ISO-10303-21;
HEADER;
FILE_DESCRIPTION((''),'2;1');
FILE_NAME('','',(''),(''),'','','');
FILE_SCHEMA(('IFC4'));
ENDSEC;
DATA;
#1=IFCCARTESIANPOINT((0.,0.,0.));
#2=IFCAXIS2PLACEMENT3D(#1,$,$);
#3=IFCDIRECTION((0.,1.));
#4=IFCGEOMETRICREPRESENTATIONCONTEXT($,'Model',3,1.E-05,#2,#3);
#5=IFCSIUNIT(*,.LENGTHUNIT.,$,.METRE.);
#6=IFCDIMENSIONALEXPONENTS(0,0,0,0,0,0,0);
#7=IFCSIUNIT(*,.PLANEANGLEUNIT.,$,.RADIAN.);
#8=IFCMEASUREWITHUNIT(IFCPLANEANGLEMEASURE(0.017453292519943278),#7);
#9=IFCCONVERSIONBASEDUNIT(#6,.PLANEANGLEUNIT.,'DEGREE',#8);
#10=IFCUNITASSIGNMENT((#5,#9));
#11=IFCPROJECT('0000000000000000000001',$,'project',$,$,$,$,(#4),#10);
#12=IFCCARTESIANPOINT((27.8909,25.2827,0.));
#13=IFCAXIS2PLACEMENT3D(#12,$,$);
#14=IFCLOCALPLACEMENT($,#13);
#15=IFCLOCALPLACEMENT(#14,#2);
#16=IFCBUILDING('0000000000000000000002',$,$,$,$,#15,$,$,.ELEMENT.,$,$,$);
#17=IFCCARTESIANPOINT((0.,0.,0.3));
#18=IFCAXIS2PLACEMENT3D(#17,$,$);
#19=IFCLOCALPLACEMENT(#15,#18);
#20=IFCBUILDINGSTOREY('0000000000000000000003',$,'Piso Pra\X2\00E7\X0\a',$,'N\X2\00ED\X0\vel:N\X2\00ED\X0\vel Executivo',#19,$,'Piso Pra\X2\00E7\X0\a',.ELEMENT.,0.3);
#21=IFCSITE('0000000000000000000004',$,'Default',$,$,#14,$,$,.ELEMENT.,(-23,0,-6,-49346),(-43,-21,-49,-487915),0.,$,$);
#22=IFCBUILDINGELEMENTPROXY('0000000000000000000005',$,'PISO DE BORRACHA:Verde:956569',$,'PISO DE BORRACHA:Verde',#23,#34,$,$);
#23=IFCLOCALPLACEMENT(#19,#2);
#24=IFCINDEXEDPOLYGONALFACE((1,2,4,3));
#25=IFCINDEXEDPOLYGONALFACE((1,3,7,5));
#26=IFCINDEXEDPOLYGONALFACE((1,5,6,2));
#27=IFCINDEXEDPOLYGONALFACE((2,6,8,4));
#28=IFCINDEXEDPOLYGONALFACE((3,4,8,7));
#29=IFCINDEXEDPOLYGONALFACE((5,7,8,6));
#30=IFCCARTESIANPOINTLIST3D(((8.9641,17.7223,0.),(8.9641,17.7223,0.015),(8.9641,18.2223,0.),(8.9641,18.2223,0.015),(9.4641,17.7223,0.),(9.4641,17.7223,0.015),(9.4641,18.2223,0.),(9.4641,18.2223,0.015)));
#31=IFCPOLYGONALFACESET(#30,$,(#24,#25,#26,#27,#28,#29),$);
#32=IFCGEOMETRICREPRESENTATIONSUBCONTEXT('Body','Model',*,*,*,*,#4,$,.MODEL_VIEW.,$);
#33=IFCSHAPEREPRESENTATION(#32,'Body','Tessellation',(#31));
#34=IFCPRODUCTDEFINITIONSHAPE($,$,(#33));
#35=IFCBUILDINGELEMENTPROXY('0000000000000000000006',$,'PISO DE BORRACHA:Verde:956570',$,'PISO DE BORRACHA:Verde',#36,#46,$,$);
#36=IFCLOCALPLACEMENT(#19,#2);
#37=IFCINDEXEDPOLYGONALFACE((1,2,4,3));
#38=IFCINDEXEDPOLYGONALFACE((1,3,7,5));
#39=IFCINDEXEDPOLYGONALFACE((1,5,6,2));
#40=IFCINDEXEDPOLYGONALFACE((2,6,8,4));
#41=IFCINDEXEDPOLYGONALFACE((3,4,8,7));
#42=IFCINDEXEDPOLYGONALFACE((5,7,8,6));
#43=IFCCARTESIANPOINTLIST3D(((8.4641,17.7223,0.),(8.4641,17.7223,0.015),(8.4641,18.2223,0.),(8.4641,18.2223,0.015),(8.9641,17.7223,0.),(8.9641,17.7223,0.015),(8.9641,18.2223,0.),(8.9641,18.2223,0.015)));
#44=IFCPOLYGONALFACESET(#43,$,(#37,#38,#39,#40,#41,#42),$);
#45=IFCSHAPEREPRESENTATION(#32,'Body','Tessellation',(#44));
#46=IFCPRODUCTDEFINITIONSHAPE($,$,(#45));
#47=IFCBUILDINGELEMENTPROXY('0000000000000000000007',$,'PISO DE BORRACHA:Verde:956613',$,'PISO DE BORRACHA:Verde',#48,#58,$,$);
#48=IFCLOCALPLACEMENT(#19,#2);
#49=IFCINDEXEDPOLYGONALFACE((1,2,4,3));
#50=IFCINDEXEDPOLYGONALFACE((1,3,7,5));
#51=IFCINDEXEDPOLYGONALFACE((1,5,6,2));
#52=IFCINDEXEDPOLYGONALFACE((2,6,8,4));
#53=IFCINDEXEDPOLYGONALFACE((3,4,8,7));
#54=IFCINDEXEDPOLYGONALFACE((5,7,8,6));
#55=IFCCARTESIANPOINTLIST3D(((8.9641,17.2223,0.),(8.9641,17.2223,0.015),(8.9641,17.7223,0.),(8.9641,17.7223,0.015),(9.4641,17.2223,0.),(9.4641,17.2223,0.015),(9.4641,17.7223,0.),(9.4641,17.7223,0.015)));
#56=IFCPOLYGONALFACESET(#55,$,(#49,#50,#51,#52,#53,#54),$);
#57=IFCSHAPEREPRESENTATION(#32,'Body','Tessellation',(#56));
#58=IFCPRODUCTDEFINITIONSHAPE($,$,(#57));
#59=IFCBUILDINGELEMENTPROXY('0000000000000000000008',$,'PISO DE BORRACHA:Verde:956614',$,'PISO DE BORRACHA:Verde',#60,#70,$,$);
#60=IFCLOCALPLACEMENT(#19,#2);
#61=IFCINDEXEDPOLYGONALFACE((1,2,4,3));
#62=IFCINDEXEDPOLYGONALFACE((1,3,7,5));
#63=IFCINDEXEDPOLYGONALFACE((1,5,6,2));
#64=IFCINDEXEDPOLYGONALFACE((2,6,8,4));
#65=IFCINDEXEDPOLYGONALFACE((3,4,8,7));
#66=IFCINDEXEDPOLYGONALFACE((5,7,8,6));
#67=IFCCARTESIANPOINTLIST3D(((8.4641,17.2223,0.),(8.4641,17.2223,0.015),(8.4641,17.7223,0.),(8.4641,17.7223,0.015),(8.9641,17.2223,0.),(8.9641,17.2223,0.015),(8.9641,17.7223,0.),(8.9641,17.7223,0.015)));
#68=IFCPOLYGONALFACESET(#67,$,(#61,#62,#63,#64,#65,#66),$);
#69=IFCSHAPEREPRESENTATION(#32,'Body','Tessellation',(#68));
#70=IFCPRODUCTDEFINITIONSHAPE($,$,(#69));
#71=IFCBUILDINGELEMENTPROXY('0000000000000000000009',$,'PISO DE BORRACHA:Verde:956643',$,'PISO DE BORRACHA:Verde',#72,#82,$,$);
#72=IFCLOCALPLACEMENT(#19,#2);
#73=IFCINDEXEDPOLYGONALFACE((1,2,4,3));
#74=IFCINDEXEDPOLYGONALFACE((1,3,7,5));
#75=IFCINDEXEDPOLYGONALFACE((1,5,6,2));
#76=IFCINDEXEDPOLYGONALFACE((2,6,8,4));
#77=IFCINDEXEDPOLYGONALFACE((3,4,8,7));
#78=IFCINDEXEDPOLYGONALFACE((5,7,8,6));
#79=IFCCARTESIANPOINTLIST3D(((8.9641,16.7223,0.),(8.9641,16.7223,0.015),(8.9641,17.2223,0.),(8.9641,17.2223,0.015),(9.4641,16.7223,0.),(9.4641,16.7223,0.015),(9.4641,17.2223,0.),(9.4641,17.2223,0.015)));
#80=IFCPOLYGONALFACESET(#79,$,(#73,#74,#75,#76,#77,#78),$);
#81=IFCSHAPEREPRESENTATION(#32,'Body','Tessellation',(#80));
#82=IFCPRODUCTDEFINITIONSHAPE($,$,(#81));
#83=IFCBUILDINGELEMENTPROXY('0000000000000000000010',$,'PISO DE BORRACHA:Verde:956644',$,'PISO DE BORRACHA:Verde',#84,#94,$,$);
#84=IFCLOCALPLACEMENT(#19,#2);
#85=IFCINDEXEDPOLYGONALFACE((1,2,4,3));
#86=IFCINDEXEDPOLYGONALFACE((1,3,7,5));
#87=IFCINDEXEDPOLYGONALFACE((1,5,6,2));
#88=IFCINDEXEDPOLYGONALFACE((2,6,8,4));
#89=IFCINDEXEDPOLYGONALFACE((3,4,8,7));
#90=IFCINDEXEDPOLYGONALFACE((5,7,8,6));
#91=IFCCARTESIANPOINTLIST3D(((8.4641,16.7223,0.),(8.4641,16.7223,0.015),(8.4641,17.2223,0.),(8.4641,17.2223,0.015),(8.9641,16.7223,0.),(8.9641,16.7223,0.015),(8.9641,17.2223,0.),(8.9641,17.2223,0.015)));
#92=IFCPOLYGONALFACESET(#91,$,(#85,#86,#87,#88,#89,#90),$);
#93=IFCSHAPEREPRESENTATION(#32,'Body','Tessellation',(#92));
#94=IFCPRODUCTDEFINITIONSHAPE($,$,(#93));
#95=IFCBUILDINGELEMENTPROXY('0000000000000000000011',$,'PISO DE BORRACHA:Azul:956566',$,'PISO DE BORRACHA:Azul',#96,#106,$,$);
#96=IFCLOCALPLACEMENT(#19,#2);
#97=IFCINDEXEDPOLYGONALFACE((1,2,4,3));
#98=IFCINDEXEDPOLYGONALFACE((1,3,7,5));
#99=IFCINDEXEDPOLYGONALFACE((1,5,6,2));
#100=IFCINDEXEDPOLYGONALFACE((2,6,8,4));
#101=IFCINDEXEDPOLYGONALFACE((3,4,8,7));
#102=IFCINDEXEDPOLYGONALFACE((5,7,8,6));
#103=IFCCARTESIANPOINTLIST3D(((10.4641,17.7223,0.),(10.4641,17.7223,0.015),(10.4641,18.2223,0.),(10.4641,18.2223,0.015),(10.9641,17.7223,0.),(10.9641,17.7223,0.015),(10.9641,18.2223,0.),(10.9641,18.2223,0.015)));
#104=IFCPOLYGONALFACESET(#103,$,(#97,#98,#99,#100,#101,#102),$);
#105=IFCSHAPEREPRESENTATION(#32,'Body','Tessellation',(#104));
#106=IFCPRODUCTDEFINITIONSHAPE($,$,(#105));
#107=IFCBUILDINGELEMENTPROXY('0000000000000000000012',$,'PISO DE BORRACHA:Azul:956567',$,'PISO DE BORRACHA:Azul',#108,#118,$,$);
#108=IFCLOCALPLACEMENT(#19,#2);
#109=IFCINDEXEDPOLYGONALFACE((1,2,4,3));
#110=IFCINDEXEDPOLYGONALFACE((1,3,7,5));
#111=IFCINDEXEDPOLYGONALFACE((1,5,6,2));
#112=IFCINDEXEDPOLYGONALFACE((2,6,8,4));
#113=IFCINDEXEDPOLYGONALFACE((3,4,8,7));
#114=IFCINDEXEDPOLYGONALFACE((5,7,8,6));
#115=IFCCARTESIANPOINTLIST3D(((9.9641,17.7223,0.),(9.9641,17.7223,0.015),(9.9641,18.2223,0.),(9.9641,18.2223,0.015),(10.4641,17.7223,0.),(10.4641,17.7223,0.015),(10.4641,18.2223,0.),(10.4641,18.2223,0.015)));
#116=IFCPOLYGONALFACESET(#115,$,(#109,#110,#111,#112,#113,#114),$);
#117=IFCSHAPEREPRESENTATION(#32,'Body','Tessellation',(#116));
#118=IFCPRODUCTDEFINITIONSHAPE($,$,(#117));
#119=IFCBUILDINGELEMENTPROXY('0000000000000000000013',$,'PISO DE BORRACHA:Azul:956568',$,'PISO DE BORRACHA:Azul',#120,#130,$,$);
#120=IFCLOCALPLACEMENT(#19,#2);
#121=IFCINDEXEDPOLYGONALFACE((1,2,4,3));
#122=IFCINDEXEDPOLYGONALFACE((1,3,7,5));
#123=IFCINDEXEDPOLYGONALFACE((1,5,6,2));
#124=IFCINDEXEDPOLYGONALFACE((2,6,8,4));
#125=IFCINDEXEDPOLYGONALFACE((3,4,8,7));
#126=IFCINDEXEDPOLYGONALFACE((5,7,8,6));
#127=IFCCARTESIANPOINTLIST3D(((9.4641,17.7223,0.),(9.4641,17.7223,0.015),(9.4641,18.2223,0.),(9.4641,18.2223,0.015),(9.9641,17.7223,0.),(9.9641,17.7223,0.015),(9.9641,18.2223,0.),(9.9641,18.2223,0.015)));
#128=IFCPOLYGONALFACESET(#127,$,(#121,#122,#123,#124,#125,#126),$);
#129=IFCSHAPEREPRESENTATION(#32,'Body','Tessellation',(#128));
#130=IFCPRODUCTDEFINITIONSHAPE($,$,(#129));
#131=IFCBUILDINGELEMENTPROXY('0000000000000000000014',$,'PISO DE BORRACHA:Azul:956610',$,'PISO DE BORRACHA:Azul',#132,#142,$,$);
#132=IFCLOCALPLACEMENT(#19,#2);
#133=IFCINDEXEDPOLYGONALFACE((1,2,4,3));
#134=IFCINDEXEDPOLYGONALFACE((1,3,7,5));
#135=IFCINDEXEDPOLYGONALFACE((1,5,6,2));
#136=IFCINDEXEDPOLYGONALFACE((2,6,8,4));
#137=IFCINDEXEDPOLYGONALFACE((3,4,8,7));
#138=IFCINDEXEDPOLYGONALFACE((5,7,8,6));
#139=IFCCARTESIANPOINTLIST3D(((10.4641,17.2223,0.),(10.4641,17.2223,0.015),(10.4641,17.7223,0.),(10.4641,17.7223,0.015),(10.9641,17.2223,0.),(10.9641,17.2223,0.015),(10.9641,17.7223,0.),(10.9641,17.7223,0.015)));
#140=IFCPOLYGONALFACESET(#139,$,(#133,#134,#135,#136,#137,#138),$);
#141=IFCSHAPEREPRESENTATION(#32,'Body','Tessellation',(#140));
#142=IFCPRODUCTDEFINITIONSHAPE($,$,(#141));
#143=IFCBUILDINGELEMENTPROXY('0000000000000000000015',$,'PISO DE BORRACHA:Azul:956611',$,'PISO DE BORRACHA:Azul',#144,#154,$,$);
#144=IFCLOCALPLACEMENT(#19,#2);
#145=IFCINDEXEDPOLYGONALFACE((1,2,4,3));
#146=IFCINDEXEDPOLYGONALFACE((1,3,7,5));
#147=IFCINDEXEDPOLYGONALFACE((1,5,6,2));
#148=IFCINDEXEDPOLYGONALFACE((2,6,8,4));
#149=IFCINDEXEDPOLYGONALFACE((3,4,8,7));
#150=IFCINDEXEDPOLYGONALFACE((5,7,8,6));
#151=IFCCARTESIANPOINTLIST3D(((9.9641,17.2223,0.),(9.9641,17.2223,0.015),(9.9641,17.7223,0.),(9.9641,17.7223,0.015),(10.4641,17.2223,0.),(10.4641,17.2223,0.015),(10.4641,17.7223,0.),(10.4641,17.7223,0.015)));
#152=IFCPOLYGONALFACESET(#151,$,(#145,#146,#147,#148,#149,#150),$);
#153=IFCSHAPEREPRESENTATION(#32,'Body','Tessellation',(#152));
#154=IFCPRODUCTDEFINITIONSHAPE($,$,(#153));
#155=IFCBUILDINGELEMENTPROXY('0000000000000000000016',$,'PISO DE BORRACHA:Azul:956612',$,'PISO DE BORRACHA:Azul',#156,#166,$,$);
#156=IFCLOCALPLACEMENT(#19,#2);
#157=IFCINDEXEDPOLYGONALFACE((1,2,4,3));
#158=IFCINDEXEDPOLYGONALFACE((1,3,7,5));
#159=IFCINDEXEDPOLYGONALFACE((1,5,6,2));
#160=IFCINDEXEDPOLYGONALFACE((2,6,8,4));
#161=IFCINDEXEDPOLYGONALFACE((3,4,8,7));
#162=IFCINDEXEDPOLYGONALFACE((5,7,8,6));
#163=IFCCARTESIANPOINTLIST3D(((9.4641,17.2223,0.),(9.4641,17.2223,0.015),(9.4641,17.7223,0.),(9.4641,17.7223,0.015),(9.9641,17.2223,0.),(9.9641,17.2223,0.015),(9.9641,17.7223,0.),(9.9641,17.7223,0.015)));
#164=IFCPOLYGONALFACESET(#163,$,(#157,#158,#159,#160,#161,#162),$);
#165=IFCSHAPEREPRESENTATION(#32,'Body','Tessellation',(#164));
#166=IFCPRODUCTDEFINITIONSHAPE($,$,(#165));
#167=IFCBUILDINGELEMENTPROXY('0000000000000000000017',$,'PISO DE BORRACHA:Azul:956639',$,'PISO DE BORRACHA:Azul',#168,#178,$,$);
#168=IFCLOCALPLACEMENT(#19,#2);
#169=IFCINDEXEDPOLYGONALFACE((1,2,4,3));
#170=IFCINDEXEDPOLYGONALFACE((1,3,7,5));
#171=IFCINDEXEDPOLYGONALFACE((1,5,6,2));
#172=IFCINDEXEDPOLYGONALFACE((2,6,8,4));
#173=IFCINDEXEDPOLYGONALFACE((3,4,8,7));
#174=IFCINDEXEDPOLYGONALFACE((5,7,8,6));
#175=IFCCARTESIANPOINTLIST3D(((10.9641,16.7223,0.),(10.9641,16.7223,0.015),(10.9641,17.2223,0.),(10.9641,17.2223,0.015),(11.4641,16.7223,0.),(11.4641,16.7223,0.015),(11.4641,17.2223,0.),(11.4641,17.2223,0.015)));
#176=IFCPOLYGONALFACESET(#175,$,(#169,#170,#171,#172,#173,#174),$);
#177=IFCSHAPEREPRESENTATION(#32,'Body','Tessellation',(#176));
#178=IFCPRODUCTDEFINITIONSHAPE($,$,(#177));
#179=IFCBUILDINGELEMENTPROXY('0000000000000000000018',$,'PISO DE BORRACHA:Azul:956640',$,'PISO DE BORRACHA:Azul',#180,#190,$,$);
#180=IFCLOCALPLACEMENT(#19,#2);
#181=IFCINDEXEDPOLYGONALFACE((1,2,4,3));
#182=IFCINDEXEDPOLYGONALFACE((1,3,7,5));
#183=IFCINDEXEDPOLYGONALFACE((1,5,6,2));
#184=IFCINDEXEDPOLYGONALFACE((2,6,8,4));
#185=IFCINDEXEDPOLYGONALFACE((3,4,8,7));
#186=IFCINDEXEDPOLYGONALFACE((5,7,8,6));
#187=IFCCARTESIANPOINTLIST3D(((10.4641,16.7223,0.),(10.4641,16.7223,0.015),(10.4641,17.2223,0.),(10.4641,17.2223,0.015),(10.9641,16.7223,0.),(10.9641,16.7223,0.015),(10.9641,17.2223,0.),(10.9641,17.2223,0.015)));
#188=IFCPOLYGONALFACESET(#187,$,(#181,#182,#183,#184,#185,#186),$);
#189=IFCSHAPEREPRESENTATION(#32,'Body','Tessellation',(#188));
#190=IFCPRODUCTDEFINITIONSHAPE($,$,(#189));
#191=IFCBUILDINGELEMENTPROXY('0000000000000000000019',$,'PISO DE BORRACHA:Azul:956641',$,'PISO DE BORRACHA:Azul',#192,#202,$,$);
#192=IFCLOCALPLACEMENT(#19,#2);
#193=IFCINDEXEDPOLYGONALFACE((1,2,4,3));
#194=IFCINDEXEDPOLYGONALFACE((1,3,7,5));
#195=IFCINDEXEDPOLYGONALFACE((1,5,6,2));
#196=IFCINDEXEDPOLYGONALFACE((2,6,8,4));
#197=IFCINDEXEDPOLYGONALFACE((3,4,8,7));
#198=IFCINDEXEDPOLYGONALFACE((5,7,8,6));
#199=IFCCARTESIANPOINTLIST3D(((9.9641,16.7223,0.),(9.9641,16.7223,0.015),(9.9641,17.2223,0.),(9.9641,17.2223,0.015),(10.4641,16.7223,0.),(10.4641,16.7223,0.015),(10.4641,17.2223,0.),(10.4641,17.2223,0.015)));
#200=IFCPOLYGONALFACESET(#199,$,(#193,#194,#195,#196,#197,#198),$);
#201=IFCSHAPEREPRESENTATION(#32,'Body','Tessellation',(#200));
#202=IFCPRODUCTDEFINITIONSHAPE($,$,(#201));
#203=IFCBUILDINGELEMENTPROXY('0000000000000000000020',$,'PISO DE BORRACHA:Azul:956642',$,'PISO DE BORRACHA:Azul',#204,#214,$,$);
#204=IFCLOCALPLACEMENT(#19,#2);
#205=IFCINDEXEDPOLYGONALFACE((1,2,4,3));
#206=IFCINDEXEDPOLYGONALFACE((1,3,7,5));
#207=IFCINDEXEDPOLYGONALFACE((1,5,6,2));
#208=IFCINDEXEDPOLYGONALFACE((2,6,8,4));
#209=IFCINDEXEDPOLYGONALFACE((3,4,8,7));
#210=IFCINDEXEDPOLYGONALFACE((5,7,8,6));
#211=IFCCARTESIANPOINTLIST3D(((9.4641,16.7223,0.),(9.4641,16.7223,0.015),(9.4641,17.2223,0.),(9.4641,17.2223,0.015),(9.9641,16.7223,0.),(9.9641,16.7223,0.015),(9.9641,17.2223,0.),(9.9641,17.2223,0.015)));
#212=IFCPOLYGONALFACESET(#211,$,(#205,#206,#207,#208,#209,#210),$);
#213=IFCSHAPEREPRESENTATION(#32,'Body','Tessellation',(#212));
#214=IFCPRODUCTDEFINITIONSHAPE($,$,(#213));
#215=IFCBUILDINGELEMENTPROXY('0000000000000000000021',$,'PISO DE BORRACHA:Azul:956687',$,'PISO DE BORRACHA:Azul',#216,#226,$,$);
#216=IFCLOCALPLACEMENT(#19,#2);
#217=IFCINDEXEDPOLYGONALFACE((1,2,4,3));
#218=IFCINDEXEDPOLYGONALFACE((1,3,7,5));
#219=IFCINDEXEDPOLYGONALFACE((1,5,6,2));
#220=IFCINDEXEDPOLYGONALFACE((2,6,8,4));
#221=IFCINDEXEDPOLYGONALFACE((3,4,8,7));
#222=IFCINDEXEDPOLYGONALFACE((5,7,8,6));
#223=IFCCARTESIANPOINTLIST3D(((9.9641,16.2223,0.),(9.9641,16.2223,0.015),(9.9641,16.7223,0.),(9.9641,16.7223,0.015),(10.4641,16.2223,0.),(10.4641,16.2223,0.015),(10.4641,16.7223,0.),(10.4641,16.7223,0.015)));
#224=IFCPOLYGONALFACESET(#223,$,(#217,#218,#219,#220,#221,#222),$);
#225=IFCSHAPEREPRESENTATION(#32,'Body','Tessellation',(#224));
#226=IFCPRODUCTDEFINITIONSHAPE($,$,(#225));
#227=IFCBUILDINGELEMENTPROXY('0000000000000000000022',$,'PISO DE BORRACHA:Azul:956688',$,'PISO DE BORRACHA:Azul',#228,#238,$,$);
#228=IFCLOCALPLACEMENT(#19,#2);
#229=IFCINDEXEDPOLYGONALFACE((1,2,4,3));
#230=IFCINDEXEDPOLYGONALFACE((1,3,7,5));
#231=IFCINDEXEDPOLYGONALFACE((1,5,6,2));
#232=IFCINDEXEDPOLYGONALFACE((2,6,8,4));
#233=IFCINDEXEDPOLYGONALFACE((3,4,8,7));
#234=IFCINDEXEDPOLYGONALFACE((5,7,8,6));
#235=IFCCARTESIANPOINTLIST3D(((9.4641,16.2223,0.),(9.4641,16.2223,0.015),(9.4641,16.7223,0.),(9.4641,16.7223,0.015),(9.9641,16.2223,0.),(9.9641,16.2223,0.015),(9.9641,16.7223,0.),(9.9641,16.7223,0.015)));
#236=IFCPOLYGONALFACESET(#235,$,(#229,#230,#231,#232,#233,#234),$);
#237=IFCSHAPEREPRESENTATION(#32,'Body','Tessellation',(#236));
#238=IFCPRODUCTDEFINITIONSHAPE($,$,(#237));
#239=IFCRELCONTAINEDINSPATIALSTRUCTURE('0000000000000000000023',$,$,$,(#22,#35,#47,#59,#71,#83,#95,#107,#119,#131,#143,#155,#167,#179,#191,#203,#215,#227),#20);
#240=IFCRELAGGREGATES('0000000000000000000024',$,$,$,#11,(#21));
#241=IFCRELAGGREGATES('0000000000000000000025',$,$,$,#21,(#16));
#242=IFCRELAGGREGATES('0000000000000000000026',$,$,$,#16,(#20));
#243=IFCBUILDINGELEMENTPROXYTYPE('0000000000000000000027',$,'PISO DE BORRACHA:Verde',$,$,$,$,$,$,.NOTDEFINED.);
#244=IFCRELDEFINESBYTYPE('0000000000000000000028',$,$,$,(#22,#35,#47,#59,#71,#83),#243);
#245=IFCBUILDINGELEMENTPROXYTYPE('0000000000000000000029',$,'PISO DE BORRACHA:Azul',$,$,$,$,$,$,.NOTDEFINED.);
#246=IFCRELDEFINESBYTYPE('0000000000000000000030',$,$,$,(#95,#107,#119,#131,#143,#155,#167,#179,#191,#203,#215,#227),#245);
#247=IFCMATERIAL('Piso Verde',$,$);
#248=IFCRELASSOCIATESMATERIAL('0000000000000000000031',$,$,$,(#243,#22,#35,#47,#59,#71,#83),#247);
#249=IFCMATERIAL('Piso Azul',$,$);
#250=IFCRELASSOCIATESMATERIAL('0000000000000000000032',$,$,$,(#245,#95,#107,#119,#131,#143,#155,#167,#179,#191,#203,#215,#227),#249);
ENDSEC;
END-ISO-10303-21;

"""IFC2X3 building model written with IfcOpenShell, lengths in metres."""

from ifc_helpers import new_model, entity, si_unit, converted_unit, direction, frame, origin, origin_2d_with_axis, place, context, subcontext, project, spatial, rectangle, extrude, source, transform, mapped, material, type_object, type_shapes, element, save


model = new_model("IFC2X3")

# Units and contexts
model_context = context("Model", 3, precision=1e-05, world=origin(), true_north=direction((0.0, 1.0)))
body_context = subcontext(model_context, "Body", "Model", "MODEL_VIEW")
ifc_project = project(units=[si_unit("LENGTHUNIT", "METRE"), converted_unit("PLANEANGLEUNIT", "DEGREE", entity("IfcPlaneAngleMeasure", 0.017453292519943278), si_unit("PLANEANGLEUNIT", "RADIAN"), dimensions=[0, 0, 0, 0, 0, 0, 0])], contexts=[model_context])

# Site, building, storey
site_placement = place(None, frame((27.8909, 25.2827, 0.0)))
site = spatial("IfcSite", under=ifc_project, at=site_placement, Name="Default", CompositionType="ELEMENT", RefLatitude=(-23, 0, -6, -49346), RefLongitude=(-43, -21, -49, -487915), RefElevation=0.0)
building_placement = place(site_placement, origin())
building = spatial("IfcBuilding", under=site, at=building_placement, CompositionType="ELEMENT")
storey_placement = place(building_placement, frame((0.0, 0.0, 0.3)))
storey = spatial("IfcBuildingStorey", under=building, at=storey_placement, Name="Piso Praça", ObjectType="Nível:Nível Executivo", LongName="Piso Praça", CompositionType="ELEMENT", Elevation=0.3)

# Building element proxies
ifc_material_1 = material(Name="Piso Verde")
building_element_proxy_type_1 = type_object("IfcBuildingElementProxyType", Name="PISO DE BORRACHA:Verde", PredefinedType="NOTDEFINED", material=ifc_material_1)
shared_shape_1 = source(origin(), body_context, "Body", "SweptSolid", [
    extrude(rectangle(XDim=0.5, YDim=0.5, at=origin_2d_with_axis()), frame((0.25, 0.25, 0.0), z_axis=(0.0, 0.0, 1.0), x_axis=(-1.0, 0.0, 0.0)), (0.0, 0.0, 1.0), 0.015),
])
type_shapes(building_element_proxy_type_1, [shared_shape_1])
for number, where, name in (
    (1, (8.9641, 17.7223, 0.0), "PISO DE BORRACHA:Verde:956569"),
    (2, (8.4641, 17.7223, 0.0), "PISO DE BORRACHA:Verde:956570"),
    (3, (8.9641, 17.2223, 0.0), "PISO DE BORRACHA:Verde:956613"),
    (4, (8.4641, 17.2223, 0.0), "PISO DE BORRACHA:Verde:956614"),
    (5, (8.9641, 16.7223, 0.0), "PISO DE BORRACHA:Verde:956643"),
    (6, (8.4641, 16.7223, 0.0), "PISO DE BORRACHA:Verde:956644"),
):
    element("IfcBuildingElementProxy", number, at=place(storey_placement, frame(where)), inside=storey, type_object=building_element_proxy_type_1, material=ifc_material_1, Name=name, ObjectType="PISO DE BORRACHA:Verde", context=body_context, shape_type="MappedRepresentation", body=[
        mapped(shared_shape_1, transform((0.0, 0.0, 0.0), scale=1.0)),
    ])
ifc_material_2 = material(Name="Piso Azul")
building_element_proxy_type_2 = type_object("IfcBuildingElementProxyType", Name="PISO DE BORRACHA:Azul", PredefinedType="NOTDEFINED", material=ifc_material_2)
shared_shape_2 = source(origin(), body_context, "Body", "SweptSolid", [
    extrude(rectangle(XDim=0.5, YDim=0.5, at=origin_2d_with_axis()), frame((0.25, 0.25, 0.0), z_axis=(0.0, 0.0, 1.0), x_axis=(-1.0, 0.0, 0.0)), (0.0, 0.0, 1.0), 0.015),
])
type_shapes(building_element_proxy_type_2, [shared_shape_2])
for number, where, name in (
    (7, (10.4641, 17.7223, 0.0), "PISO DE BORRACHA:Azul:956566"),
    (8, (9.9641, 17.7223, 0.0), "PISO DE BORRACHA:Azul:956567"),
    (9, (9.4641, 17.7223, 0.0), "PISO DE BORRACHA:Azul:956568"),
    (10, (10.4641, 17.2223, 0.0), "PISO DE BORRACHA:Azul:956610"),
    (11, (9.9641, 17.2223, 0.0), "PISO DE BORRACHA:Azul:956611"),
    (12, (9.4641, 17.2223, 0.0), "PISO DE BORRACHA:Azul:956612"),
    (13, (10.9641, 16.7223, 0.0), "PISO DE BORRACHA:Azul:956639"),
    (14, (10.4641, 16.7223, 0.0), "PISO DE BORRACHA:Azul:956640"),
    (15, (9.9641, 16.7223, 0.0), "PISO DE BORRACHA:Azul:956641"),
    (16, (9.4641, 16.7223, 0.0), "PISO DE BORRACHA:Azul:956642"),
    (17, (9.9641, 16.2223, 0.0), "PISO DE BORRACHA:Azul:956687"),
    (18, (9.4641, 16.2223, 0.0), "PISO DE BORRACHA:Azul:956688"),
):
    element("IfcBuildingElementProxy", number, at=place(storey_placement, frame(where)), inside=storey, type_object=building_element_proxy_type_2, material=ifc_material_2, Name=name, ObjectType="PISO DE BORRACHA:Azul", context=body_context, shape_type="MappedRepresentation", body=[
        mapped(shared_shape_2, transform((0.0, 0.0, 0.0), scale=1.0)),
    ])

save(model, "model.ifc")
